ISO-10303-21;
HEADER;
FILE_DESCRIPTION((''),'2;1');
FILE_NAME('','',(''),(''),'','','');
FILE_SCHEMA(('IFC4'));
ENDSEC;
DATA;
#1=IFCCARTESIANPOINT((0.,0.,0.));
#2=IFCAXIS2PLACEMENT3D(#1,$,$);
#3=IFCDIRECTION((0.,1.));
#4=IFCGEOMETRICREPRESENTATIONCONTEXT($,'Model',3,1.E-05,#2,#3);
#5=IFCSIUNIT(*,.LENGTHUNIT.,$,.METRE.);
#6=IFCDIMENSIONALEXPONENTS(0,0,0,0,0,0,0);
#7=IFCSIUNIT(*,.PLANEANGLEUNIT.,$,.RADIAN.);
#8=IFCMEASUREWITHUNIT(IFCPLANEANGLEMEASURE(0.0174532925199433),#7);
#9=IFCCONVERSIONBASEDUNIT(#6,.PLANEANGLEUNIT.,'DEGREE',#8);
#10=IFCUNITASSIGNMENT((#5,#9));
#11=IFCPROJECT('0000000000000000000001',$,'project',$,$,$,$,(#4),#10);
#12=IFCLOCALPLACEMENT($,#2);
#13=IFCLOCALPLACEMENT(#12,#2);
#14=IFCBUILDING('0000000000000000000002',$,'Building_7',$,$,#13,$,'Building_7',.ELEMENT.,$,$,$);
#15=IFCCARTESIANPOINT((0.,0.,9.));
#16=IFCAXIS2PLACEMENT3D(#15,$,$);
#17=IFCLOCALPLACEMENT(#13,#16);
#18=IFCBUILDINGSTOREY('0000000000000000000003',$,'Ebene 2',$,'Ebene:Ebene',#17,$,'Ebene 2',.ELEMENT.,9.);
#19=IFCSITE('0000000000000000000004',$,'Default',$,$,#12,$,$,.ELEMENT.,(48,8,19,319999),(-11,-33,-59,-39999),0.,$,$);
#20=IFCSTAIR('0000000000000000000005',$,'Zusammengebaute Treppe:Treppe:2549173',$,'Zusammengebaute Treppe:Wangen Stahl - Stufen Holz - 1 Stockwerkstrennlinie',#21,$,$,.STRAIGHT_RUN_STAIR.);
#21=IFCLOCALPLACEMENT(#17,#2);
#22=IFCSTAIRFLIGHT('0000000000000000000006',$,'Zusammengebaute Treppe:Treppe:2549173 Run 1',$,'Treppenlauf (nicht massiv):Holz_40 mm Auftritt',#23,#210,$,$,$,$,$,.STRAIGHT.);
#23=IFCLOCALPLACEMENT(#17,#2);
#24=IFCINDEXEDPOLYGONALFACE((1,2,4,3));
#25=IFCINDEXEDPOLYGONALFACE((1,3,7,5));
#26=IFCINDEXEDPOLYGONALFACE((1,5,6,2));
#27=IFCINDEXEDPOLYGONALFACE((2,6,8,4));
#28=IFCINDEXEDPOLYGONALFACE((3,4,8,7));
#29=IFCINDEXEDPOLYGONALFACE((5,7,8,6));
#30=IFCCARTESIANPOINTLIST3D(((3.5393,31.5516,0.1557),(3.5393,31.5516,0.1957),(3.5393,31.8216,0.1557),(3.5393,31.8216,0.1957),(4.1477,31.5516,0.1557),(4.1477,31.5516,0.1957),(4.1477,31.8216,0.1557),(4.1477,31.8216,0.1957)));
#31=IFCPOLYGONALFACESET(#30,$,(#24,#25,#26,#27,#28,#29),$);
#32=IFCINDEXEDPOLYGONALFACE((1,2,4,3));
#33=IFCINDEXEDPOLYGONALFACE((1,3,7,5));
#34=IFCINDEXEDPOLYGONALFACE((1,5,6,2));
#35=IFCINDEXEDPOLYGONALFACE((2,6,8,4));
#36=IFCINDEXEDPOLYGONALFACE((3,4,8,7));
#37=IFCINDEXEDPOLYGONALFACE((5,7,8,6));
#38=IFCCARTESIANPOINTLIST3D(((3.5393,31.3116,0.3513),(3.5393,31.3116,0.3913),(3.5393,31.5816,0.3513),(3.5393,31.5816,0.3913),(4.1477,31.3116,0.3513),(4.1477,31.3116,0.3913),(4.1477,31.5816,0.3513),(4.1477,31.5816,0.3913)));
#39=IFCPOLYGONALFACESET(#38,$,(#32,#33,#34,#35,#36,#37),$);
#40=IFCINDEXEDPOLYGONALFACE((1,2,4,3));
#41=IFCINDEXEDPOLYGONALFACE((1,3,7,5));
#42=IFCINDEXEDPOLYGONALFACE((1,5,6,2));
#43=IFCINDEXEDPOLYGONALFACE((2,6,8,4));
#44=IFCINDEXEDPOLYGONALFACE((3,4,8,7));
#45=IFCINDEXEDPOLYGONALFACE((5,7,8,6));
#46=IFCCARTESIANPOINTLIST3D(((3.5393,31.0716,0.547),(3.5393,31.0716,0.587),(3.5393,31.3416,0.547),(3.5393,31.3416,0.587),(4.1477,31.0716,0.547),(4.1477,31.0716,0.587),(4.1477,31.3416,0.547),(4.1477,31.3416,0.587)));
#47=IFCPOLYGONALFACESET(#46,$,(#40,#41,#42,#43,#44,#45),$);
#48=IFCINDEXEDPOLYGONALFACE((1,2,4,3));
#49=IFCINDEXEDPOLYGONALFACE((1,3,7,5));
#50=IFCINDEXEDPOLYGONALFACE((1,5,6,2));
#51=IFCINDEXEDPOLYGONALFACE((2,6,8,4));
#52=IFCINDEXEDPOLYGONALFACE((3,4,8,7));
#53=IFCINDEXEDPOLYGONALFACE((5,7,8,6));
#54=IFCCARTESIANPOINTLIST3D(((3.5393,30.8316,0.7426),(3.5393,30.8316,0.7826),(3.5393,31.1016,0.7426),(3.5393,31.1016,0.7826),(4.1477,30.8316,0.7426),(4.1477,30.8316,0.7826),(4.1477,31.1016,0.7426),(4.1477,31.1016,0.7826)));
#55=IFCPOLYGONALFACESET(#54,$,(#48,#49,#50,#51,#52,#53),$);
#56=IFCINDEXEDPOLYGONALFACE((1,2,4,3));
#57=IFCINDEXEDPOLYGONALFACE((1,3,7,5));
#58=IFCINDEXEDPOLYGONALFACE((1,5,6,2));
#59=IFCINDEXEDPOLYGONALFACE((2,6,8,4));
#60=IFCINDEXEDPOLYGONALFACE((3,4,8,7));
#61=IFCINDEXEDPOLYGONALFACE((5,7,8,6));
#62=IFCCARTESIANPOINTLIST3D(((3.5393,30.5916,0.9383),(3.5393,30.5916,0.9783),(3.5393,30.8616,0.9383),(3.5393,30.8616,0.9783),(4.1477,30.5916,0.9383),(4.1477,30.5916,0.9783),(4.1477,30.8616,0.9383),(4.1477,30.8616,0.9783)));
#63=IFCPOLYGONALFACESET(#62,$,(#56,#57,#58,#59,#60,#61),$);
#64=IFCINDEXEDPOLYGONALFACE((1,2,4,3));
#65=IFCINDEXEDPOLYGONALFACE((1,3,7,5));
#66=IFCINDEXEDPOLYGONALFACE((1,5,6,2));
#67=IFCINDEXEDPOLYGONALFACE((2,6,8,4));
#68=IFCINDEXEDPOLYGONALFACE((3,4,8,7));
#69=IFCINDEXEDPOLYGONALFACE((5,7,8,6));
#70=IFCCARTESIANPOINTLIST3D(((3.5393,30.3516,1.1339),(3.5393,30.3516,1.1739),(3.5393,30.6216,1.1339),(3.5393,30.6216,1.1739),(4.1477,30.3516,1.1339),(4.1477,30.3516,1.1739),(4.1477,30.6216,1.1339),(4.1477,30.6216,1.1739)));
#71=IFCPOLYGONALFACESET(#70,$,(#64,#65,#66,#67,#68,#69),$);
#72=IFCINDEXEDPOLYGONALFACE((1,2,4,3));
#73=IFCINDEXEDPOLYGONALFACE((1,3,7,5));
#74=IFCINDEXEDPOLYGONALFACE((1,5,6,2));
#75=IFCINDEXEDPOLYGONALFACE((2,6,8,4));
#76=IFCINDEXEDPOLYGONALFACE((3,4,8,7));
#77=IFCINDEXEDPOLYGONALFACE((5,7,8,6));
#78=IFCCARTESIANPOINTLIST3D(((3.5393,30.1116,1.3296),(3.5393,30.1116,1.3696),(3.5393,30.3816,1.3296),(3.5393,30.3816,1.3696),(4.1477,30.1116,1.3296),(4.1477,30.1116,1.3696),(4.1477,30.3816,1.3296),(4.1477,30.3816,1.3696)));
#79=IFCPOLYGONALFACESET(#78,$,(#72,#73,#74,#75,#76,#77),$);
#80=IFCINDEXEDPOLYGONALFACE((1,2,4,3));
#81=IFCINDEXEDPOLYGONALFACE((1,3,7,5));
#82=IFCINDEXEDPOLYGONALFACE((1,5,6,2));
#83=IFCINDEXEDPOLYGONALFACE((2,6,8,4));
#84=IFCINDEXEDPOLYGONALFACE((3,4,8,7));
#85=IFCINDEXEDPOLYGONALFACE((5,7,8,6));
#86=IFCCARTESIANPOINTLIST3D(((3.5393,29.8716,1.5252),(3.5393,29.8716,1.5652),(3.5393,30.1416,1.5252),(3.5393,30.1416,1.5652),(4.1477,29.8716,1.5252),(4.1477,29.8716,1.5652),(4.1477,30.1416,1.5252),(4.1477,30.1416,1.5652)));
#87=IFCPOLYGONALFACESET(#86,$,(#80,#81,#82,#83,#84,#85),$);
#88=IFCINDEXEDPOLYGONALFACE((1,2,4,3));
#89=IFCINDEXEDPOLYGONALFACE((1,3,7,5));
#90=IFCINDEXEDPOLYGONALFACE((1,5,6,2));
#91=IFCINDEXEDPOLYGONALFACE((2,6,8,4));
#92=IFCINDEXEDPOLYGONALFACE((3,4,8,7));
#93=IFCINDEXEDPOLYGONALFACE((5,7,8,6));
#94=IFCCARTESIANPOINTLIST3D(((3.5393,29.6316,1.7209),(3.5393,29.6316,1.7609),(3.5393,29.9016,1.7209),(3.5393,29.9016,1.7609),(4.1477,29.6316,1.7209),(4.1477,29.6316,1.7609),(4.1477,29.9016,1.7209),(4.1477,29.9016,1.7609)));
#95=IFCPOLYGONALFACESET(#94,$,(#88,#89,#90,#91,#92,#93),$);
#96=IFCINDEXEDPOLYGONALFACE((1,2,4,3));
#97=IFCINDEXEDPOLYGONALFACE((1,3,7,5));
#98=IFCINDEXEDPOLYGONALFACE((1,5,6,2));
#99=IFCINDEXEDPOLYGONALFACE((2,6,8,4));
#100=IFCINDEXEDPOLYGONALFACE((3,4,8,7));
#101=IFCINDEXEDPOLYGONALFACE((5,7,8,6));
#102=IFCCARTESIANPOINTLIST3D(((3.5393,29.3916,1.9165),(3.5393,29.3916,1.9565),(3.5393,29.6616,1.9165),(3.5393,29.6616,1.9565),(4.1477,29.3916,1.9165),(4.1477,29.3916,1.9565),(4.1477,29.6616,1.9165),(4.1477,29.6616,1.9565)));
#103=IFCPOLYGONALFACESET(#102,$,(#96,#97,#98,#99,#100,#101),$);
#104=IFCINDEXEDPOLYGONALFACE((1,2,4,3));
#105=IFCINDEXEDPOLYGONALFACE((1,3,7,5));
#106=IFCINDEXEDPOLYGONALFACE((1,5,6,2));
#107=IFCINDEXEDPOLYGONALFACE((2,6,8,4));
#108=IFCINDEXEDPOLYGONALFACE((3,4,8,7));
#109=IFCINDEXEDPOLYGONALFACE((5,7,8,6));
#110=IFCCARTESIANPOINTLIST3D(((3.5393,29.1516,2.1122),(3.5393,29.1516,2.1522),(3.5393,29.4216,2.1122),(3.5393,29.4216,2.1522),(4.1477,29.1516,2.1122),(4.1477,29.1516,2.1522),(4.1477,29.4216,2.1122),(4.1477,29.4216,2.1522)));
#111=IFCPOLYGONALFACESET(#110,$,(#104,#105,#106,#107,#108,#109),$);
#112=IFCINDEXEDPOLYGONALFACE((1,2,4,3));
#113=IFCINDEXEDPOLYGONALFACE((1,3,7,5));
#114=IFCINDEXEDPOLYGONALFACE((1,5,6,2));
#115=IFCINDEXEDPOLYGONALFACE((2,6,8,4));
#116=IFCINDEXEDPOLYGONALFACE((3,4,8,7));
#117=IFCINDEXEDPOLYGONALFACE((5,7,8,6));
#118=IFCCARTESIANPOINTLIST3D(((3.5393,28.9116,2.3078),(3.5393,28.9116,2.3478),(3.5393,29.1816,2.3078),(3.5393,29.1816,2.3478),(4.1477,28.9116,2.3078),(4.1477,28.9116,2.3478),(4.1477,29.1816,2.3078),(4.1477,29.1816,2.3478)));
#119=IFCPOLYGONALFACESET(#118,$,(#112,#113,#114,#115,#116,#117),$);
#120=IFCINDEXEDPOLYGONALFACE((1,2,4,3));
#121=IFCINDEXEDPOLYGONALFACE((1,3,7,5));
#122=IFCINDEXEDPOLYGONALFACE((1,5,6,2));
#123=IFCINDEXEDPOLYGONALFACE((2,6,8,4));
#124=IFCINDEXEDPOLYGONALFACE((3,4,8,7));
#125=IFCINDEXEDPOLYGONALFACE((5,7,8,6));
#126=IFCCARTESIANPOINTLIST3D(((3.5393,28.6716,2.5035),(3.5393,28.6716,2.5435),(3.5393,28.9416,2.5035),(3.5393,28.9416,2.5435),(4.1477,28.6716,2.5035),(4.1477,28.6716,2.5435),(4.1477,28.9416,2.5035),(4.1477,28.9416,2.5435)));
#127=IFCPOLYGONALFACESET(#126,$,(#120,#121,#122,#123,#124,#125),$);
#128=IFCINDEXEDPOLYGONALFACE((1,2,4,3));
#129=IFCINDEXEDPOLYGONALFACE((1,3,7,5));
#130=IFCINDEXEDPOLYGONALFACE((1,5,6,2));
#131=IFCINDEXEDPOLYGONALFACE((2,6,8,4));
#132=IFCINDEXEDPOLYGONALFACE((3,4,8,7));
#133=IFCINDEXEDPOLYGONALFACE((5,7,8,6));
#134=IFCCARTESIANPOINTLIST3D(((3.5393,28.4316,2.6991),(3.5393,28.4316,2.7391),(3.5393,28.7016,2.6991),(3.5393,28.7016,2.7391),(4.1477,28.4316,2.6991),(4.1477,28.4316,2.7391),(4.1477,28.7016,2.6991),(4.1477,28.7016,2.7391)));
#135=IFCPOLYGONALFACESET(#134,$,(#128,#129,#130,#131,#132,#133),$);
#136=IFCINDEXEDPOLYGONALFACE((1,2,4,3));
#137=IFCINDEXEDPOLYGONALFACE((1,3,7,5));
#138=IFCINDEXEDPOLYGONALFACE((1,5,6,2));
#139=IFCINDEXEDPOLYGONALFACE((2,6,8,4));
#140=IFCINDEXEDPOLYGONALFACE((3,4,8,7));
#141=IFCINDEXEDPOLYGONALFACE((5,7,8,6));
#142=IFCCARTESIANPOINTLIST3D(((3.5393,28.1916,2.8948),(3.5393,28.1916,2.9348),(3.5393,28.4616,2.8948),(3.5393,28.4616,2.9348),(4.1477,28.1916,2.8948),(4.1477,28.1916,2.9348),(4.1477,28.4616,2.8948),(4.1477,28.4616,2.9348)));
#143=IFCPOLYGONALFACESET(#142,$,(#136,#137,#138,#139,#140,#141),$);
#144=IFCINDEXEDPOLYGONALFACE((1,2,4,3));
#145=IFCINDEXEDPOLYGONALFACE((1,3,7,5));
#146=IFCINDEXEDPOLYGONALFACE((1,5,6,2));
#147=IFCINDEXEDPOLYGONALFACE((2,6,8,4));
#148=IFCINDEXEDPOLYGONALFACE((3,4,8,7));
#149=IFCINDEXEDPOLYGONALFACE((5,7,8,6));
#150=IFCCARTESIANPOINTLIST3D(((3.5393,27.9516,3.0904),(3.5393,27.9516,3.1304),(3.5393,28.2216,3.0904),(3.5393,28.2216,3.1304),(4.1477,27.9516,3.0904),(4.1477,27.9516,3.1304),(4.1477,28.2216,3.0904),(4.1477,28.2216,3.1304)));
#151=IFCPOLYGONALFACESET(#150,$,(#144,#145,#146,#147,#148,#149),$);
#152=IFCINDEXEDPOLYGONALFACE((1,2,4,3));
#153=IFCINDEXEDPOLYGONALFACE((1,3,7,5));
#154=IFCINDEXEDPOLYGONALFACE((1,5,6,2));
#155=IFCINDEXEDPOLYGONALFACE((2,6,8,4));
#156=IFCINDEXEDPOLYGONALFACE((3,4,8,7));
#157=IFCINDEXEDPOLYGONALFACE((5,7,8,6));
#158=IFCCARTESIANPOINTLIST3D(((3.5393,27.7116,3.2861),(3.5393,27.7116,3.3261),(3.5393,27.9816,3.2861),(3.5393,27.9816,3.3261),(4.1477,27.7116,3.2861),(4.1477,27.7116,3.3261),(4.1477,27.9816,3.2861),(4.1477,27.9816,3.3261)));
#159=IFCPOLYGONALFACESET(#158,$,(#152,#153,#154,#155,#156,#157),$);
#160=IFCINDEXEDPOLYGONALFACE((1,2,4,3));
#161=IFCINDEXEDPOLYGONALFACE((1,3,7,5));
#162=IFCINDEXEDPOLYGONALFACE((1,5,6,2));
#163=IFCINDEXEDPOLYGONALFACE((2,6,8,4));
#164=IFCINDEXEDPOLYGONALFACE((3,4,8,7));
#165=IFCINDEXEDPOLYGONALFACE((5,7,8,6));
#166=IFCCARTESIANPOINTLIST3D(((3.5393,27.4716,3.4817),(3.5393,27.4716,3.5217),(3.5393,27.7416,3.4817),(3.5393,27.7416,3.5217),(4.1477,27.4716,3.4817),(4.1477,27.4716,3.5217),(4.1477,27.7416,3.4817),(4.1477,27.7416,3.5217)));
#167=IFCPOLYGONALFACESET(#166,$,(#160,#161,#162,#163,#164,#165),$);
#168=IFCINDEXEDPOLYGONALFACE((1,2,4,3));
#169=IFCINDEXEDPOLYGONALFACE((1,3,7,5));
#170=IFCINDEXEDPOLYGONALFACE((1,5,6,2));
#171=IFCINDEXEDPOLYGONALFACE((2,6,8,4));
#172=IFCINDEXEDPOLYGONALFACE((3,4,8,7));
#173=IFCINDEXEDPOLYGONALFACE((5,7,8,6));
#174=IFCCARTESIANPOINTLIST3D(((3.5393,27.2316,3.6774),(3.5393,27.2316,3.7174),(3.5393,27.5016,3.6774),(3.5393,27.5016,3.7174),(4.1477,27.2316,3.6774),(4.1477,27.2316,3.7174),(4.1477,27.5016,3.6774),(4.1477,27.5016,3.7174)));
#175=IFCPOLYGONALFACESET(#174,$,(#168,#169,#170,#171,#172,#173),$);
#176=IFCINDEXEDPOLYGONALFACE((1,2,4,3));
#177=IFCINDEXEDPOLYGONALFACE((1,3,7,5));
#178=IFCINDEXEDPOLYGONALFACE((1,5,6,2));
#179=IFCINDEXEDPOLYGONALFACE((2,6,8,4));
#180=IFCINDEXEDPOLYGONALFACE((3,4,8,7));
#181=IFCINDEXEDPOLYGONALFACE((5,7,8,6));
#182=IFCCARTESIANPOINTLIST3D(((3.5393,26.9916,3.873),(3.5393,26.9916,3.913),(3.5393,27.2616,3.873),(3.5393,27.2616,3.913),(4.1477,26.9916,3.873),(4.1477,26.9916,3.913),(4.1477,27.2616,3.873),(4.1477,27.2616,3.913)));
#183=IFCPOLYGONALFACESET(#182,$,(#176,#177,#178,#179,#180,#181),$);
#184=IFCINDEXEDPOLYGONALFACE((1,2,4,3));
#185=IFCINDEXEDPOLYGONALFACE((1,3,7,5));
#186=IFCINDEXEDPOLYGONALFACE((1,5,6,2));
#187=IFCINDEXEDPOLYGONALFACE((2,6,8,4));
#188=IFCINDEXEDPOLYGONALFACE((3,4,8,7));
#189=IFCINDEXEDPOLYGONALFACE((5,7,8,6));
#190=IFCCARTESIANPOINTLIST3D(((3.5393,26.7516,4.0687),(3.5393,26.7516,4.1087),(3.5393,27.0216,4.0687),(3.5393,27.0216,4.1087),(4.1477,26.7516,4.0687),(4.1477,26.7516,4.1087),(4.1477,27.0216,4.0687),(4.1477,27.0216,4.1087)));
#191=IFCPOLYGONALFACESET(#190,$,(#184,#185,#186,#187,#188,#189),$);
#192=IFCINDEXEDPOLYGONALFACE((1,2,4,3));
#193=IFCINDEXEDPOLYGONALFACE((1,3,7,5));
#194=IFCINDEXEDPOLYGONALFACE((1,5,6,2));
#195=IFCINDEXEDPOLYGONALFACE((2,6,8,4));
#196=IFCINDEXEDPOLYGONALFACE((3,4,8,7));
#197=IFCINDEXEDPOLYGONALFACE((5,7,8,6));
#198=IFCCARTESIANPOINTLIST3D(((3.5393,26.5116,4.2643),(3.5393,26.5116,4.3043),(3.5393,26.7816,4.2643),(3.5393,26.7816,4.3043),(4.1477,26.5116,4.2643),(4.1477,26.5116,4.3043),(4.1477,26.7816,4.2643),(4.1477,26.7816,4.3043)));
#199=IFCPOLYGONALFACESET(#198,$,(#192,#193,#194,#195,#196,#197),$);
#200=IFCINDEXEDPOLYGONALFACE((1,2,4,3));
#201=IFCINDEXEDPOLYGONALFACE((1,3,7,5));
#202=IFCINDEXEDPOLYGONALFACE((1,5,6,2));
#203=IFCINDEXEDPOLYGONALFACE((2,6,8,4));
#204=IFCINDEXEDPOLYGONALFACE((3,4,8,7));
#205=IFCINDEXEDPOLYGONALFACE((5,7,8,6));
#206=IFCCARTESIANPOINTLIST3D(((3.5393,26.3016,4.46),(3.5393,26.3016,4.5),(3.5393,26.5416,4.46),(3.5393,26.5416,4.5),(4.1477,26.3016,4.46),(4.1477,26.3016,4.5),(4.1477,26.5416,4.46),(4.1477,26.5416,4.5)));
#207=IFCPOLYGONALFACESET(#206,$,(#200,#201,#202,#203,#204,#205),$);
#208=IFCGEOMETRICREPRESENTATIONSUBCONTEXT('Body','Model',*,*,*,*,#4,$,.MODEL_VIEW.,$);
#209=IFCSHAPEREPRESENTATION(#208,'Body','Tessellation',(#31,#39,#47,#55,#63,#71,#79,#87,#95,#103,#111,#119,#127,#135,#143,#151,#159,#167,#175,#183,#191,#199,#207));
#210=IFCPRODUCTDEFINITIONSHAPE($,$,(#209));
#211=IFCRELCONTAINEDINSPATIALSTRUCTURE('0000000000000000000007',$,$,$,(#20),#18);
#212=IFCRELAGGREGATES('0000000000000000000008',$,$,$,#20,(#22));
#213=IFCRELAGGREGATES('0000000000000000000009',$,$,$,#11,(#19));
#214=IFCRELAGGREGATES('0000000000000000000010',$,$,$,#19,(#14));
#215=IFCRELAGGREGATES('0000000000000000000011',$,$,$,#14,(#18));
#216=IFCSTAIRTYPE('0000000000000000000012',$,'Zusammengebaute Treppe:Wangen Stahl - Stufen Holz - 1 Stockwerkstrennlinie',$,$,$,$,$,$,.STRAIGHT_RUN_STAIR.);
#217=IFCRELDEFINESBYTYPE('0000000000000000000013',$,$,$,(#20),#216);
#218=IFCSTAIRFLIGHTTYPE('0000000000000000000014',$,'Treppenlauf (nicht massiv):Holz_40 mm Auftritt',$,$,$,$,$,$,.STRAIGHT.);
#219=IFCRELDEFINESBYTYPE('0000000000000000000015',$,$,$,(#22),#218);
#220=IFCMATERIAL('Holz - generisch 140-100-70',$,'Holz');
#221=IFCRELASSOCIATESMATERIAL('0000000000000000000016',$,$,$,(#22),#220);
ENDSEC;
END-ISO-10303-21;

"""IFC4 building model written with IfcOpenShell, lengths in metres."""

from ifc_helpers import new_model, entity, si_unit, converted_unit, direction, frame, origin, place, context, subcontext, project, spatial, indexed_curve, outline, extrude, material, type_object, element, aggregate, save


model = new_model("IFC4")

# Units and contexts
model_context = context("Model", 3, precision=1e-05, world=origin(), true_north=direction((0.0, 1.0)))
body_context = subcontext(model_context, "Body", "Model", "MODEL_VIEW")
ifc_project = project(units=[si_unit("LENGTHUNIT", "METRE"), converted_unit("PLANEANGLEUNIT", "DEGREE", entity("IfcPlaneAngleMeasure", 0.0174532925199433), si_unit("PLANEANGLEUNIT", "RADIAN"), dimensions=[0, 0, 0, 0, 0, 0, 0])], contexts=[model_context])

# Site, building, storey
site_placement = place(None, origin())
site = spatial("IfcSite", under=ifc_project, at=site_placement, Name="Default", CompositionType="ELEMENT", RefLatitude=(48, 8, 19, 319999), RefLongitude=(-11, -33, -59, -39999), RefElevation=0.0)
building_placement = place(site_placement, origin())
building = spatial("IfcBuilding", under=site, at=building_placement, Name="Building_7", LongName="Building_7", CompositionType="ELEMENT")
storey_placement = place(building_placement, frame((0.0, 0.0, 9.0)))
storey = spatial("IfcBuildingStorey", under=building, at=storey_placement, Name="Ebene 2", ObjectType="Ebene:Ebene", LongName="Ebene 2", CompositionType="ELEMENT", Elevation=9.0)

# Stair
stair_type = type_object("IfcStairType", Name="Zusammengebaute Treppe:Wangen Stahl - Stufen Holz - 1 Stockwerkstrennlinie", PredefinedType="STRAIGHT_RUN_STAIR")
stair_placement = place(storey_placement, origin())
stair = element("IfcStair", 1, at=stair_placement, inside=storey, type_object=stair_type, Name="Zusammengebaute Treppe:Treppe:2549173", ObjectType="Zusammengebaute Treppe:Wangen Stahl - Stufen Holz - 1 Stockwerkstrennlinie", PredefinedType="STRAIGHT_RUN_STAIR")

# Stair flight
ifc_material_1 = material(Name="Holz - generisch 140-100-70", Category="Holz")
stair_flight_type = type_object("IfcStairFlightType", Name="Treppenlauf (nicht massiv):Holz_40 mm Auftritt", PredefinedType="STRAIGHT")
stair_flight_placement = place(stair_placement, origin())
stair_flight = element("IfcStairFlight", 2, at=stair_flight_placement, type_object=stair_flight_type, material=ifc_material_1, Name="Zusammengebaute Treppe:Treppe:2549173 Run 1", ObjectType="Treppenlauf (nicht massiv):Holz_40 mm Auftritt", PredefinedType="STRAIGHT", context=body_context, shape_type="SweptSolid", body=[
    extrude(outline(indexed_curve([(-0.135, -0.3042), (0.135, -0.3042), (0.135, 0.3042), (-0.135, 0.3042), (-0.135, -0.3042)], self_intersect=False)), frame((3.8435, 31.6866, 0.1557), z_axis=(0.0, 0.0, 1.0), x_axis=(0.0, 1.0, 0.0)), (0.0, 0.0, 1.0), 0.04),
    extrude(outline(indexed_curve([(-0.135, -0.3042), (0.135, -0.3042), (0.135, 0.3042), (-0.135, 0.3042), (-0.135, -0.3042)], self_intersect=False)), frame((3.8435, 31.4466, 0.3513), z_axis=(0.0, 0.0, 1.0), x_axis=(0.0, 1.0, 0.0)), (0.0, 0.0, 1.0), 0.04),
    extrude(outline(indexed_curve([(-0.135, -0.3042), (0.135, -0.3042), (0.135, 0.3042), (-0.135, 0.3042), (-0.135, -0.3042)], self_intersect=False)), frame((3.8435, 31.2066, 0.547), z_axis=(0.0, 0.0, 1.0), x_axis=(0.0, 1.0, 0.0)), (0.0, 0.0, 1.0), 0.04),
    extrude(outline(indexed_curve([(-0.135, -0.3042), (0.135, -0.3042), (0.135, 0.3042), (-0.135, 0.3042), (-0.135, -0.3042)], self_intersect=False)), frame((3.8435, 30.9666, 0.7426), z_axis=(0.0, 0.0, 1.0), x_axis=(0.0, 1.0, 0.0)), (0.0, 0.0, 1.0), 0.04),
    extrude(outline(indexed_curve([(-0.135, -0.3042), (0.135, -0.3042), (0.135, 0.3042), (-0.135, 0.3042), (-0.135, -0.3042)], self_intersect=False)), frame((3.8435, 30.7266, 0.9383), z_axis=(0.0, 0.0, 1.0), x_axis=(0.0, 1.0, 0.0)), (0.0, 0.0, 1.0), 0.04),
    extrude(outline(indexed_curve([(-0.135, -0.3042), (0.135, -0.3042), (0.135, 0.3042), (-0.135, 0.3042), (-0.135, -0.3042)], self_intersect=False)), frame((3.8435, 30.4866, 1.1339), z_axis=(0.0, 0.0, 1.0), x_axis=(0.0, 1.0, 0.0)), (0.0, 0.0, 1.0), 0.04),
    extrude(outline(indexed_curve([(-0.135, -0.3042), (0.135, -0.3042), (0.135, 0.3042), (-0.135, 0.3042), (-0.135, -0.3042)], self_intersect=False)), frame((3.8435, 30.2466, 1.3296), z_axis=(0.0, 0.0, 1.0), x_axis=(0.0, 1.0, 0.0)), (0.0, 0.0, 1.0), 0.04),
    extrude(outline(indexed_curve([(-0.135, -0.3042), (0.135, -0.3042), (0.135, 0.3042), (-0.135, 0.3042), (-0.135, -0.3042)], self_intersect=False)), frame((3.8435, 30.0066, 1.5252), z_axis=(0.0, 0.0, 1.0), x_axis=(0.0, 1.0, 0.0)), (0.0, 0.0, 1.0), 0.04),
    extrude(outline(indexed_curve([(-0.135, -0.3042), (0.135, -0.3042), (0.135, 0.3042), (-0.135, 0.3042), (-0.135, -0.3042)], self_intersect=False)), frame((3.8435, 29.7666, 1.7209), z_axis=(0.0, 0.0, 1.0), x_axis=(0.0, 1.0, 0.0)), (0.0, 0.0, 1.0), 0.04),
    extrude(outline(indexed_curve([(-0.135, -0.3042), (0.135, -0.3042), (0.135, 0.3042), (-0.135, 0.3042), (-0.135, -0.3042)], self_intersect=False)), frame((3.8435, 29.5266, 1.9165), z_axis=(0.0, 0.0, 1.0), x_axis=(0.0, 1.0, 0.0)), (0.0, 0.0, 1.0), 0.04),
    extrude(outline(indexed_curve([(-0.135, -0.3042), (0.135, -0.3042), (0.135, 0.3042), (-0.135, 0.3042), (-0.135, -0.3042)], self_intersect=False)), frame((3.8435, 29.2866, 2.1122), z_axis=(0.0, 0.0, 1.0), x_axis=(0.0, 1.0, 0.0)), (0.0, 0.0, 1.0), 0.04),
    extrude(outline(indexed_curve([(-0.135, -0.3042), (0.135, -0.3042), (0.135, 0.3042), (-0.135, 0.3042), (-0.135, -0.3042)], self_intersect=False)), frame((3.8435, 29.0466, 2.3078), z_axis=(0.0, 0.0, 1.0), x_axis=(0.0, 1.0, 0.0)), (0.0, 0.0, 1.0), 0.04),
    extrude(outline(indexed_curve([(-0.135, -0.3042), (0.135, -0.3042), (0.135, 0.3042), (-0.135, 0.3042), (-0.135, -0.3042)], self_intersect=False)), frame((3.8435, 28.8066, 2.5035), z_axis=(0.0, 0.0, 1.0), x_axis=(0.0, 1.0, 0.0)), (0.0, 0.0, 1.0), 0.04),
    extrude(outline(indexed_curve([(-0.135, -0.3042), (0.135, -0.3042), (0.135, 0.3042), (-0.135, 0.3042), (-0.135, -0.3042)], self_intersect=False)), frame((3.8435, 28.5666, 2.6991), z_axis=(0.0, 0.0, 1.0), x_axis=(0.0, 1.0, 0.0)), (0.0, 0.0, 1.0), 0.04),
    extrude(outline(indexed_curve([(-0.135, -0.3042), (0.135, -0.3042), (0.135, 0.3042), (-0.135, 0.3042), (-0.135, -0.3042)], self_intersect=False)), frame((3.8435, 28.3266, 2.8948), z_axis=(0.0, 0.0, 1.0), x_axis=(0.0, 1.0, 0.0)), (0.0, 0.0, 1.0), 0.04),
    extrude(outline(indexed_curve([(-0.135, -0.3042), (0.135, -0.3042), (0.135, 0.3042), (-0.135, 0.3042), (-0.135, -0.3042)], self_intersect=False)), frame((3.8435, 28.0866, 3.0904), z_axis=(0.0, 0.0, 1.0), x_axis=(0.0, 1.0, 0.0)), (0.0, 0.0, 1.0), 0.04),
    extrude(outline(indexed_curve([(-0.135, -0.3042), (0.135, -0.3042), (0.135, 0.3042), (-0.135, 0.3042), (-0.135, -0.3042)], self_intersect=False)), frame((3.8435, 27.8466, 3.2861), z_axis=(0.0, 0.0, 1.0), x_axis=(0.0, 1.0, 0.0)), (0.0, 0.0, 1.0), 0.04),
    extrude(outline(indexed_curve([(-0.135, -0.3042), (0.135, -0.3042), (0.135, 0.3042), (-0.135, 0.3042), (-0.135, -0.3042)], self_intersect=False)), frame((3.8435, 27.6066, 3.4817), z_axis=(0.0, 0.0, 1.0), x_axis=(0.0, 1.0, 0.0)), (0.0, 0.0, 1.0), 0.04),
    extrude(outline(indexed_curve([(-0.135, -0.3042), (0.135, -0.3042), (0.135, 0.3042), (-0.135, 0.3042), (-0.135, -0.3042)], self_intersect=False)), frame((3.8435, 27.3666, 3.6774), z_axis=(0.0, 0.0, 1.0), x_axis=(0.0, 1.0, 0.0)), (0.0, 0.0, 1.0), 0.04),
    extrude(outline(indexed_curve([(-0.135, -0.3042), (0.135, -0.3042), (0.135, 0.3042), (-0.135, 0.3042), (-0.135, -0.3042)], self_intersect=False)), frame((3.8435, 27.1266, 3.873), z_axis=(0.0, 0.0, 1.0), x_axis=(0.0, 1.0, 0.0)), (0.0, 0.0, 1.0), 0.04),
    extrude(outline(indexed_curve([(-0.135, -0.3042), (0.135, -0.3042), (0.135, 0.3042), (-0.135, 0.3042), (-0.135, -0.3042)], self_intersect=False)), frame((3.8435, 26.8866, 4.0687), z_axis=(0.0, 0.0, 1.0), x_axis=(0.0, 1.0, 0.0)), (0.0, 0.0, 1.0), 0.04),
    extrude(outline(indexed_curve([(-0.135, -0.3042), (0.135, -0.3042), (0.135, 0.3042), (-0.135, 0.3042), (-0.135, -0.3042)], self_intersect=False)), frame((3.8435, 26.6466, 4.2643), z_axis=(0.0, 0.0, 1.0), x_axis=(0.0, 1.0, 0.0)), (0.0, 0.0, 1.0), 0.04),
    extrude(outline(indexed_curve([(-0.12, -0.3042), (0.12, -0.3042), (0.12, 0.3042), (-0.12, 0.3042), (-0.12, -0.3042)], self_intersect=False)), frame((3.8435, 26.4216, 4.46), z_axis=(0.0, 0.0, 1.0), x_axis=(0.0, 1.0, 0.0)), (0.0, 0.0, 1.0), 0.04),
])
aggregate(stair, [stair_flight])

save(model, "model.ifc")
